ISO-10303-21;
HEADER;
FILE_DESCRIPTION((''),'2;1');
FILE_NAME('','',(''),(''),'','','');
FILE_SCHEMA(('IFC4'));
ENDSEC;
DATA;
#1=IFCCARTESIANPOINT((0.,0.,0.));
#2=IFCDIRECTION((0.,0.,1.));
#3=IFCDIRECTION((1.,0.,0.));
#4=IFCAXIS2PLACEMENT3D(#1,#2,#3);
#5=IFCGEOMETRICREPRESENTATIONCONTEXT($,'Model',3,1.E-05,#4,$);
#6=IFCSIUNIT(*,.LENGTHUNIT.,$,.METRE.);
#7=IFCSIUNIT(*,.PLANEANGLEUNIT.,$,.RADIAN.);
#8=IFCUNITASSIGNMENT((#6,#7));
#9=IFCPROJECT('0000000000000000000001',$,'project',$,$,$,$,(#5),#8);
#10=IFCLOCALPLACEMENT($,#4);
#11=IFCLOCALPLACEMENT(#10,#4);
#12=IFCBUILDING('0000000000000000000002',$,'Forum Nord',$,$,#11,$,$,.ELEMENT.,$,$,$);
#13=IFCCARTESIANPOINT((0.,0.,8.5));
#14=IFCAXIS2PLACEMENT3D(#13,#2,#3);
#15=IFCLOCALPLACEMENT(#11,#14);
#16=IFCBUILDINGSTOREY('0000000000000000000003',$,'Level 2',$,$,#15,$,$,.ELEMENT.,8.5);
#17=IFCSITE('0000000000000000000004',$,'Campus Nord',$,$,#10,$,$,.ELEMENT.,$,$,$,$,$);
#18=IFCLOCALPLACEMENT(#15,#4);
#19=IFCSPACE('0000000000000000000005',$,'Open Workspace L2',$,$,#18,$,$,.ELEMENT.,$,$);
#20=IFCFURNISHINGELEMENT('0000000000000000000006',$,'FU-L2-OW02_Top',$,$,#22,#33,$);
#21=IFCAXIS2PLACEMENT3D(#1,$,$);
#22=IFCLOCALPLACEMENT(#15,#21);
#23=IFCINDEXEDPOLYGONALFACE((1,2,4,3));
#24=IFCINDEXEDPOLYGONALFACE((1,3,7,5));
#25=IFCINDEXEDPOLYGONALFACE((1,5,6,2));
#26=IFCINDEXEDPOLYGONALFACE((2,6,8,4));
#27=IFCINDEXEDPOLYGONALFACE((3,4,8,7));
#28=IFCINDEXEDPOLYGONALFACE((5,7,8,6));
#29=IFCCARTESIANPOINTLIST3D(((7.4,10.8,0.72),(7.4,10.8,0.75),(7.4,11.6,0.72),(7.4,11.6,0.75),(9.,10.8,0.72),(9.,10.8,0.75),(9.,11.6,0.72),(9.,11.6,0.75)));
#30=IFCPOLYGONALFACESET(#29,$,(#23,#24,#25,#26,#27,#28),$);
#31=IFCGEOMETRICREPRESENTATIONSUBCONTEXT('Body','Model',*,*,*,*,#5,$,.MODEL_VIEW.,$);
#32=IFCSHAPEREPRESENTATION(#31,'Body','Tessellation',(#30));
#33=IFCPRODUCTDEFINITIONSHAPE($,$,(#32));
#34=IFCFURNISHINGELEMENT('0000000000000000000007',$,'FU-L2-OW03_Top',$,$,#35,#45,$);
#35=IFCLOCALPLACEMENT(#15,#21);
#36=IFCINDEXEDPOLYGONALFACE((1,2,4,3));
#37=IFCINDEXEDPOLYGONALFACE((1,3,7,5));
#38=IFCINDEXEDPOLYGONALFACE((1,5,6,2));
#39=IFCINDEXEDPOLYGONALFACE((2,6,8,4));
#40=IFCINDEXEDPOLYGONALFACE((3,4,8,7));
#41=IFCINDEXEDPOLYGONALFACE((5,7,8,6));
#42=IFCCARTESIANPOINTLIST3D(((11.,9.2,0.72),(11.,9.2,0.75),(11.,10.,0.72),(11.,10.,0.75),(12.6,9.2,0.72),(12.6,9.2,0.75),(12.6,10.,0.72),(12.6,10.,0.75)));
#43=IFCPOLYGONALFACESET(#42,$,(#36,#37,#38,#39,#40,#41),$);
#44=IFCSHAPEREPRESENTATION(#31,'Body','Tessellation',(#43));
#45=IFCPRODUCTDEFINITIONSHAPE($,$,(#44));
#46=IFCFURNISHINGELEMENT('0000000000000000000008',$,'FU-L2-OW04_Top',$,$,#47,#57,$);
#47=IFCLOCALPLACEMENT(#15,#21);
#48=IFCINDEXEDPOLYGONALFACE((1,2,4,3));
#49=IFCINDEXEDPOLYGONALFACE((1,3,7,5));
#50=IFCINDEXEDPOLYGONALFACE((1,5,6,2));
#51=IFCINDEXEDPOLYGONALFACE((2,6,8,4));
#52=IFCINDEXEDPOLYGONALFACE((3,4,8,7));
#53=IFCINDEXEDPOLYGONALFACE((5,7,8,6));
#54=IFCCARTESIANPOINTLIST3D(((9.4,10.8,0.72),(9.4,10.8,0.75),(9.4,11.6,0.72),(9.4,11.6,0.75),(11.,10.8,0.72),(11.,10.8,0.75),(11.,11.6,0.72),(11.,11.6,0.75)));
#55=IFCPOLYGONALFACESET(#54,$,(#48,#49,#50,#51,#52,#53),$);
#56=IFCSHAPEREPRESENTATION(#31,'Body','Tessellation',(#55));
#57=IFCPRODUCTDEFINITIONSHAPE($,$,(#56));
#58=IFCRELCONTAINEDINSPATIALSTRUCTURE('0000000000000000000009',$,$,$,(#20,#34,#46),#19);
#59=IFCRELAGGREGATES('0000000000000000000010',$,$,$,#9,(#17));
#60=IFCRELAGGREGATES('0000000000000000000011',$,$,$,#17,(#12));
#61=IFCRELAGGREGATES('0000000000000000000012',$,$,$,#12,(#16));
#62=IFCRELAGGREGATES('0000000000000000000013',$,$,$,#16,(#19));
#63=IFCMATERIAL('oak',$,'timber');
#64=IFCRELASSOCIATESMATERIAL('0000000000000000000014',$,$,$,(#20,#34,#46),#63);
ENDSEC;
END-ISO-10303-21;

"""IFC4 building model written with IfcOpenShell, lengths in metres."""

from ifc_helpers import new_model, si_unit, frame, frame_2d, origin_with_axes, place, context, subcontext, project, spatial, rectangle, extrude, material, element, save


model = new_model("IFC4")

# Units and contexts
model_context = context("Model", 3, precision=1e-05, world=origin_with_axes())
body_context = subcontext(model_context, "Body", "Model", "MODEL_VIEW")
ifc_project = project(units=[si_unit("LENGTHUNIT", "METRE"), si_unit("PLANEANGLEUNIT", "RADIAN")], contexts=[model_context])

# Site, building, storey, space
site_placement = place(None, origin_with_axes())
site = spatial("IfcSite", under=ifc_project, at=site_placement, Name="Campus Nord", CompositionType="ELEMENT")
building_placement = place(site_placement, origin_with_axes())
building = spatial("IfcBuilding", under=site, at=building_placement, Name="Forum Nord", CompositionType="ELEMENT")
storey_placement = place(building_placement, frame((0.0, 0.0, 8.5), z_axis=(0.0, 0.0, 1.0), x_axis=(1.0, 0.0, 0.0)))
storey = spatial("IfcBuildingStorey", under=building, at=storey_placement, Name="Level 2", CompositionType="ELEMENT", Elevation=8.5)
space_placement = place(storey_placement, origin_with_axes())
space = spatial("IfcSpace", under=storey, at=space_placement, Name="Open Workspace L2", CompositionType="ELEMENT")

# Furnishing elements
ifc_material = material(Name="oak", Category="timber")
furnishing_1_placement = place(storey_placement, frame((9.0, 12.2, 0.0), z_axis=(0.0, 0.0, 1.0), x_axis=(-1.0, 0.0, 0.0)))
element("IfcFurnishingElement", 1, at=furnishing_1_placement, inside=space, material=ifc_material, Name="FU-L2-OW02_Top", context=body_context, shape_type="SweptSolid", body=[
    extrude(rectangle(XDim=1.6, YDim=0.8, at=frame_2d((0.8, 1.0), x_axis=(1.0, 0.0))), frame((0.0, 0.0, 0.72), z_axis=(0.0, 0.0, 1.0), x_axis=(1.0, 0.0, 0.0)), (0.0, 0.0, 1.0), 0.03),
])
furnishing_2_placement = place(storey_placement, frame((11.0, 8.6, 0.0), z_axis=(0.0, 0.0, 1.0), x_axis=(1.0, 0.0, 0.0)))
element("IfcFurnishingElement", 2, at=furnishing_2_placement, inside=space, material=ifc_material, Name="FU-L2-OW03_Top", context=body_context, shape_type="SweptSolid", body=[
    extrude(rectangle(XDim=1.6, YDim=0.8, at=frame_2d((0.8, 1.0), x_axis=(1.0, 0.0))), frame((0.0, 0.0, 0.72), z_axis=(0.0, 0.0, 1.0), x_axis=(1.0, 0.0, 0.0)), (0.0, 0.0, 1.0), 0.03),
])
furnishing_3_placement = place(storey_placement, frame((11.0, 12.2, 0.0), z_axis=(0.0, 0.0, 1.0), x_axis=(-1.0, 0.0, 0.0)))
element("IfcFurnishingElement", 3, at=furnishing_3_placement, inside=space, material=ifc_material, Name="FU-L2-OW04_Top", context=body_context, shape_type="SweptSolid", body=[
    extrude(rectangle(XDim=1.6, YDim=0.8, at=frame_2d((0.8, 1.0), x_axis=(1.0, 0.0))), frame((0.0, 0.0, 0.72), z_axis=(0.0, 0.0, 1.0), x_axis=(1.0, 0.0, 0.0)), (0.0, 0.0, 1.0), 0.03),
])

save(model, "model.ifc")
